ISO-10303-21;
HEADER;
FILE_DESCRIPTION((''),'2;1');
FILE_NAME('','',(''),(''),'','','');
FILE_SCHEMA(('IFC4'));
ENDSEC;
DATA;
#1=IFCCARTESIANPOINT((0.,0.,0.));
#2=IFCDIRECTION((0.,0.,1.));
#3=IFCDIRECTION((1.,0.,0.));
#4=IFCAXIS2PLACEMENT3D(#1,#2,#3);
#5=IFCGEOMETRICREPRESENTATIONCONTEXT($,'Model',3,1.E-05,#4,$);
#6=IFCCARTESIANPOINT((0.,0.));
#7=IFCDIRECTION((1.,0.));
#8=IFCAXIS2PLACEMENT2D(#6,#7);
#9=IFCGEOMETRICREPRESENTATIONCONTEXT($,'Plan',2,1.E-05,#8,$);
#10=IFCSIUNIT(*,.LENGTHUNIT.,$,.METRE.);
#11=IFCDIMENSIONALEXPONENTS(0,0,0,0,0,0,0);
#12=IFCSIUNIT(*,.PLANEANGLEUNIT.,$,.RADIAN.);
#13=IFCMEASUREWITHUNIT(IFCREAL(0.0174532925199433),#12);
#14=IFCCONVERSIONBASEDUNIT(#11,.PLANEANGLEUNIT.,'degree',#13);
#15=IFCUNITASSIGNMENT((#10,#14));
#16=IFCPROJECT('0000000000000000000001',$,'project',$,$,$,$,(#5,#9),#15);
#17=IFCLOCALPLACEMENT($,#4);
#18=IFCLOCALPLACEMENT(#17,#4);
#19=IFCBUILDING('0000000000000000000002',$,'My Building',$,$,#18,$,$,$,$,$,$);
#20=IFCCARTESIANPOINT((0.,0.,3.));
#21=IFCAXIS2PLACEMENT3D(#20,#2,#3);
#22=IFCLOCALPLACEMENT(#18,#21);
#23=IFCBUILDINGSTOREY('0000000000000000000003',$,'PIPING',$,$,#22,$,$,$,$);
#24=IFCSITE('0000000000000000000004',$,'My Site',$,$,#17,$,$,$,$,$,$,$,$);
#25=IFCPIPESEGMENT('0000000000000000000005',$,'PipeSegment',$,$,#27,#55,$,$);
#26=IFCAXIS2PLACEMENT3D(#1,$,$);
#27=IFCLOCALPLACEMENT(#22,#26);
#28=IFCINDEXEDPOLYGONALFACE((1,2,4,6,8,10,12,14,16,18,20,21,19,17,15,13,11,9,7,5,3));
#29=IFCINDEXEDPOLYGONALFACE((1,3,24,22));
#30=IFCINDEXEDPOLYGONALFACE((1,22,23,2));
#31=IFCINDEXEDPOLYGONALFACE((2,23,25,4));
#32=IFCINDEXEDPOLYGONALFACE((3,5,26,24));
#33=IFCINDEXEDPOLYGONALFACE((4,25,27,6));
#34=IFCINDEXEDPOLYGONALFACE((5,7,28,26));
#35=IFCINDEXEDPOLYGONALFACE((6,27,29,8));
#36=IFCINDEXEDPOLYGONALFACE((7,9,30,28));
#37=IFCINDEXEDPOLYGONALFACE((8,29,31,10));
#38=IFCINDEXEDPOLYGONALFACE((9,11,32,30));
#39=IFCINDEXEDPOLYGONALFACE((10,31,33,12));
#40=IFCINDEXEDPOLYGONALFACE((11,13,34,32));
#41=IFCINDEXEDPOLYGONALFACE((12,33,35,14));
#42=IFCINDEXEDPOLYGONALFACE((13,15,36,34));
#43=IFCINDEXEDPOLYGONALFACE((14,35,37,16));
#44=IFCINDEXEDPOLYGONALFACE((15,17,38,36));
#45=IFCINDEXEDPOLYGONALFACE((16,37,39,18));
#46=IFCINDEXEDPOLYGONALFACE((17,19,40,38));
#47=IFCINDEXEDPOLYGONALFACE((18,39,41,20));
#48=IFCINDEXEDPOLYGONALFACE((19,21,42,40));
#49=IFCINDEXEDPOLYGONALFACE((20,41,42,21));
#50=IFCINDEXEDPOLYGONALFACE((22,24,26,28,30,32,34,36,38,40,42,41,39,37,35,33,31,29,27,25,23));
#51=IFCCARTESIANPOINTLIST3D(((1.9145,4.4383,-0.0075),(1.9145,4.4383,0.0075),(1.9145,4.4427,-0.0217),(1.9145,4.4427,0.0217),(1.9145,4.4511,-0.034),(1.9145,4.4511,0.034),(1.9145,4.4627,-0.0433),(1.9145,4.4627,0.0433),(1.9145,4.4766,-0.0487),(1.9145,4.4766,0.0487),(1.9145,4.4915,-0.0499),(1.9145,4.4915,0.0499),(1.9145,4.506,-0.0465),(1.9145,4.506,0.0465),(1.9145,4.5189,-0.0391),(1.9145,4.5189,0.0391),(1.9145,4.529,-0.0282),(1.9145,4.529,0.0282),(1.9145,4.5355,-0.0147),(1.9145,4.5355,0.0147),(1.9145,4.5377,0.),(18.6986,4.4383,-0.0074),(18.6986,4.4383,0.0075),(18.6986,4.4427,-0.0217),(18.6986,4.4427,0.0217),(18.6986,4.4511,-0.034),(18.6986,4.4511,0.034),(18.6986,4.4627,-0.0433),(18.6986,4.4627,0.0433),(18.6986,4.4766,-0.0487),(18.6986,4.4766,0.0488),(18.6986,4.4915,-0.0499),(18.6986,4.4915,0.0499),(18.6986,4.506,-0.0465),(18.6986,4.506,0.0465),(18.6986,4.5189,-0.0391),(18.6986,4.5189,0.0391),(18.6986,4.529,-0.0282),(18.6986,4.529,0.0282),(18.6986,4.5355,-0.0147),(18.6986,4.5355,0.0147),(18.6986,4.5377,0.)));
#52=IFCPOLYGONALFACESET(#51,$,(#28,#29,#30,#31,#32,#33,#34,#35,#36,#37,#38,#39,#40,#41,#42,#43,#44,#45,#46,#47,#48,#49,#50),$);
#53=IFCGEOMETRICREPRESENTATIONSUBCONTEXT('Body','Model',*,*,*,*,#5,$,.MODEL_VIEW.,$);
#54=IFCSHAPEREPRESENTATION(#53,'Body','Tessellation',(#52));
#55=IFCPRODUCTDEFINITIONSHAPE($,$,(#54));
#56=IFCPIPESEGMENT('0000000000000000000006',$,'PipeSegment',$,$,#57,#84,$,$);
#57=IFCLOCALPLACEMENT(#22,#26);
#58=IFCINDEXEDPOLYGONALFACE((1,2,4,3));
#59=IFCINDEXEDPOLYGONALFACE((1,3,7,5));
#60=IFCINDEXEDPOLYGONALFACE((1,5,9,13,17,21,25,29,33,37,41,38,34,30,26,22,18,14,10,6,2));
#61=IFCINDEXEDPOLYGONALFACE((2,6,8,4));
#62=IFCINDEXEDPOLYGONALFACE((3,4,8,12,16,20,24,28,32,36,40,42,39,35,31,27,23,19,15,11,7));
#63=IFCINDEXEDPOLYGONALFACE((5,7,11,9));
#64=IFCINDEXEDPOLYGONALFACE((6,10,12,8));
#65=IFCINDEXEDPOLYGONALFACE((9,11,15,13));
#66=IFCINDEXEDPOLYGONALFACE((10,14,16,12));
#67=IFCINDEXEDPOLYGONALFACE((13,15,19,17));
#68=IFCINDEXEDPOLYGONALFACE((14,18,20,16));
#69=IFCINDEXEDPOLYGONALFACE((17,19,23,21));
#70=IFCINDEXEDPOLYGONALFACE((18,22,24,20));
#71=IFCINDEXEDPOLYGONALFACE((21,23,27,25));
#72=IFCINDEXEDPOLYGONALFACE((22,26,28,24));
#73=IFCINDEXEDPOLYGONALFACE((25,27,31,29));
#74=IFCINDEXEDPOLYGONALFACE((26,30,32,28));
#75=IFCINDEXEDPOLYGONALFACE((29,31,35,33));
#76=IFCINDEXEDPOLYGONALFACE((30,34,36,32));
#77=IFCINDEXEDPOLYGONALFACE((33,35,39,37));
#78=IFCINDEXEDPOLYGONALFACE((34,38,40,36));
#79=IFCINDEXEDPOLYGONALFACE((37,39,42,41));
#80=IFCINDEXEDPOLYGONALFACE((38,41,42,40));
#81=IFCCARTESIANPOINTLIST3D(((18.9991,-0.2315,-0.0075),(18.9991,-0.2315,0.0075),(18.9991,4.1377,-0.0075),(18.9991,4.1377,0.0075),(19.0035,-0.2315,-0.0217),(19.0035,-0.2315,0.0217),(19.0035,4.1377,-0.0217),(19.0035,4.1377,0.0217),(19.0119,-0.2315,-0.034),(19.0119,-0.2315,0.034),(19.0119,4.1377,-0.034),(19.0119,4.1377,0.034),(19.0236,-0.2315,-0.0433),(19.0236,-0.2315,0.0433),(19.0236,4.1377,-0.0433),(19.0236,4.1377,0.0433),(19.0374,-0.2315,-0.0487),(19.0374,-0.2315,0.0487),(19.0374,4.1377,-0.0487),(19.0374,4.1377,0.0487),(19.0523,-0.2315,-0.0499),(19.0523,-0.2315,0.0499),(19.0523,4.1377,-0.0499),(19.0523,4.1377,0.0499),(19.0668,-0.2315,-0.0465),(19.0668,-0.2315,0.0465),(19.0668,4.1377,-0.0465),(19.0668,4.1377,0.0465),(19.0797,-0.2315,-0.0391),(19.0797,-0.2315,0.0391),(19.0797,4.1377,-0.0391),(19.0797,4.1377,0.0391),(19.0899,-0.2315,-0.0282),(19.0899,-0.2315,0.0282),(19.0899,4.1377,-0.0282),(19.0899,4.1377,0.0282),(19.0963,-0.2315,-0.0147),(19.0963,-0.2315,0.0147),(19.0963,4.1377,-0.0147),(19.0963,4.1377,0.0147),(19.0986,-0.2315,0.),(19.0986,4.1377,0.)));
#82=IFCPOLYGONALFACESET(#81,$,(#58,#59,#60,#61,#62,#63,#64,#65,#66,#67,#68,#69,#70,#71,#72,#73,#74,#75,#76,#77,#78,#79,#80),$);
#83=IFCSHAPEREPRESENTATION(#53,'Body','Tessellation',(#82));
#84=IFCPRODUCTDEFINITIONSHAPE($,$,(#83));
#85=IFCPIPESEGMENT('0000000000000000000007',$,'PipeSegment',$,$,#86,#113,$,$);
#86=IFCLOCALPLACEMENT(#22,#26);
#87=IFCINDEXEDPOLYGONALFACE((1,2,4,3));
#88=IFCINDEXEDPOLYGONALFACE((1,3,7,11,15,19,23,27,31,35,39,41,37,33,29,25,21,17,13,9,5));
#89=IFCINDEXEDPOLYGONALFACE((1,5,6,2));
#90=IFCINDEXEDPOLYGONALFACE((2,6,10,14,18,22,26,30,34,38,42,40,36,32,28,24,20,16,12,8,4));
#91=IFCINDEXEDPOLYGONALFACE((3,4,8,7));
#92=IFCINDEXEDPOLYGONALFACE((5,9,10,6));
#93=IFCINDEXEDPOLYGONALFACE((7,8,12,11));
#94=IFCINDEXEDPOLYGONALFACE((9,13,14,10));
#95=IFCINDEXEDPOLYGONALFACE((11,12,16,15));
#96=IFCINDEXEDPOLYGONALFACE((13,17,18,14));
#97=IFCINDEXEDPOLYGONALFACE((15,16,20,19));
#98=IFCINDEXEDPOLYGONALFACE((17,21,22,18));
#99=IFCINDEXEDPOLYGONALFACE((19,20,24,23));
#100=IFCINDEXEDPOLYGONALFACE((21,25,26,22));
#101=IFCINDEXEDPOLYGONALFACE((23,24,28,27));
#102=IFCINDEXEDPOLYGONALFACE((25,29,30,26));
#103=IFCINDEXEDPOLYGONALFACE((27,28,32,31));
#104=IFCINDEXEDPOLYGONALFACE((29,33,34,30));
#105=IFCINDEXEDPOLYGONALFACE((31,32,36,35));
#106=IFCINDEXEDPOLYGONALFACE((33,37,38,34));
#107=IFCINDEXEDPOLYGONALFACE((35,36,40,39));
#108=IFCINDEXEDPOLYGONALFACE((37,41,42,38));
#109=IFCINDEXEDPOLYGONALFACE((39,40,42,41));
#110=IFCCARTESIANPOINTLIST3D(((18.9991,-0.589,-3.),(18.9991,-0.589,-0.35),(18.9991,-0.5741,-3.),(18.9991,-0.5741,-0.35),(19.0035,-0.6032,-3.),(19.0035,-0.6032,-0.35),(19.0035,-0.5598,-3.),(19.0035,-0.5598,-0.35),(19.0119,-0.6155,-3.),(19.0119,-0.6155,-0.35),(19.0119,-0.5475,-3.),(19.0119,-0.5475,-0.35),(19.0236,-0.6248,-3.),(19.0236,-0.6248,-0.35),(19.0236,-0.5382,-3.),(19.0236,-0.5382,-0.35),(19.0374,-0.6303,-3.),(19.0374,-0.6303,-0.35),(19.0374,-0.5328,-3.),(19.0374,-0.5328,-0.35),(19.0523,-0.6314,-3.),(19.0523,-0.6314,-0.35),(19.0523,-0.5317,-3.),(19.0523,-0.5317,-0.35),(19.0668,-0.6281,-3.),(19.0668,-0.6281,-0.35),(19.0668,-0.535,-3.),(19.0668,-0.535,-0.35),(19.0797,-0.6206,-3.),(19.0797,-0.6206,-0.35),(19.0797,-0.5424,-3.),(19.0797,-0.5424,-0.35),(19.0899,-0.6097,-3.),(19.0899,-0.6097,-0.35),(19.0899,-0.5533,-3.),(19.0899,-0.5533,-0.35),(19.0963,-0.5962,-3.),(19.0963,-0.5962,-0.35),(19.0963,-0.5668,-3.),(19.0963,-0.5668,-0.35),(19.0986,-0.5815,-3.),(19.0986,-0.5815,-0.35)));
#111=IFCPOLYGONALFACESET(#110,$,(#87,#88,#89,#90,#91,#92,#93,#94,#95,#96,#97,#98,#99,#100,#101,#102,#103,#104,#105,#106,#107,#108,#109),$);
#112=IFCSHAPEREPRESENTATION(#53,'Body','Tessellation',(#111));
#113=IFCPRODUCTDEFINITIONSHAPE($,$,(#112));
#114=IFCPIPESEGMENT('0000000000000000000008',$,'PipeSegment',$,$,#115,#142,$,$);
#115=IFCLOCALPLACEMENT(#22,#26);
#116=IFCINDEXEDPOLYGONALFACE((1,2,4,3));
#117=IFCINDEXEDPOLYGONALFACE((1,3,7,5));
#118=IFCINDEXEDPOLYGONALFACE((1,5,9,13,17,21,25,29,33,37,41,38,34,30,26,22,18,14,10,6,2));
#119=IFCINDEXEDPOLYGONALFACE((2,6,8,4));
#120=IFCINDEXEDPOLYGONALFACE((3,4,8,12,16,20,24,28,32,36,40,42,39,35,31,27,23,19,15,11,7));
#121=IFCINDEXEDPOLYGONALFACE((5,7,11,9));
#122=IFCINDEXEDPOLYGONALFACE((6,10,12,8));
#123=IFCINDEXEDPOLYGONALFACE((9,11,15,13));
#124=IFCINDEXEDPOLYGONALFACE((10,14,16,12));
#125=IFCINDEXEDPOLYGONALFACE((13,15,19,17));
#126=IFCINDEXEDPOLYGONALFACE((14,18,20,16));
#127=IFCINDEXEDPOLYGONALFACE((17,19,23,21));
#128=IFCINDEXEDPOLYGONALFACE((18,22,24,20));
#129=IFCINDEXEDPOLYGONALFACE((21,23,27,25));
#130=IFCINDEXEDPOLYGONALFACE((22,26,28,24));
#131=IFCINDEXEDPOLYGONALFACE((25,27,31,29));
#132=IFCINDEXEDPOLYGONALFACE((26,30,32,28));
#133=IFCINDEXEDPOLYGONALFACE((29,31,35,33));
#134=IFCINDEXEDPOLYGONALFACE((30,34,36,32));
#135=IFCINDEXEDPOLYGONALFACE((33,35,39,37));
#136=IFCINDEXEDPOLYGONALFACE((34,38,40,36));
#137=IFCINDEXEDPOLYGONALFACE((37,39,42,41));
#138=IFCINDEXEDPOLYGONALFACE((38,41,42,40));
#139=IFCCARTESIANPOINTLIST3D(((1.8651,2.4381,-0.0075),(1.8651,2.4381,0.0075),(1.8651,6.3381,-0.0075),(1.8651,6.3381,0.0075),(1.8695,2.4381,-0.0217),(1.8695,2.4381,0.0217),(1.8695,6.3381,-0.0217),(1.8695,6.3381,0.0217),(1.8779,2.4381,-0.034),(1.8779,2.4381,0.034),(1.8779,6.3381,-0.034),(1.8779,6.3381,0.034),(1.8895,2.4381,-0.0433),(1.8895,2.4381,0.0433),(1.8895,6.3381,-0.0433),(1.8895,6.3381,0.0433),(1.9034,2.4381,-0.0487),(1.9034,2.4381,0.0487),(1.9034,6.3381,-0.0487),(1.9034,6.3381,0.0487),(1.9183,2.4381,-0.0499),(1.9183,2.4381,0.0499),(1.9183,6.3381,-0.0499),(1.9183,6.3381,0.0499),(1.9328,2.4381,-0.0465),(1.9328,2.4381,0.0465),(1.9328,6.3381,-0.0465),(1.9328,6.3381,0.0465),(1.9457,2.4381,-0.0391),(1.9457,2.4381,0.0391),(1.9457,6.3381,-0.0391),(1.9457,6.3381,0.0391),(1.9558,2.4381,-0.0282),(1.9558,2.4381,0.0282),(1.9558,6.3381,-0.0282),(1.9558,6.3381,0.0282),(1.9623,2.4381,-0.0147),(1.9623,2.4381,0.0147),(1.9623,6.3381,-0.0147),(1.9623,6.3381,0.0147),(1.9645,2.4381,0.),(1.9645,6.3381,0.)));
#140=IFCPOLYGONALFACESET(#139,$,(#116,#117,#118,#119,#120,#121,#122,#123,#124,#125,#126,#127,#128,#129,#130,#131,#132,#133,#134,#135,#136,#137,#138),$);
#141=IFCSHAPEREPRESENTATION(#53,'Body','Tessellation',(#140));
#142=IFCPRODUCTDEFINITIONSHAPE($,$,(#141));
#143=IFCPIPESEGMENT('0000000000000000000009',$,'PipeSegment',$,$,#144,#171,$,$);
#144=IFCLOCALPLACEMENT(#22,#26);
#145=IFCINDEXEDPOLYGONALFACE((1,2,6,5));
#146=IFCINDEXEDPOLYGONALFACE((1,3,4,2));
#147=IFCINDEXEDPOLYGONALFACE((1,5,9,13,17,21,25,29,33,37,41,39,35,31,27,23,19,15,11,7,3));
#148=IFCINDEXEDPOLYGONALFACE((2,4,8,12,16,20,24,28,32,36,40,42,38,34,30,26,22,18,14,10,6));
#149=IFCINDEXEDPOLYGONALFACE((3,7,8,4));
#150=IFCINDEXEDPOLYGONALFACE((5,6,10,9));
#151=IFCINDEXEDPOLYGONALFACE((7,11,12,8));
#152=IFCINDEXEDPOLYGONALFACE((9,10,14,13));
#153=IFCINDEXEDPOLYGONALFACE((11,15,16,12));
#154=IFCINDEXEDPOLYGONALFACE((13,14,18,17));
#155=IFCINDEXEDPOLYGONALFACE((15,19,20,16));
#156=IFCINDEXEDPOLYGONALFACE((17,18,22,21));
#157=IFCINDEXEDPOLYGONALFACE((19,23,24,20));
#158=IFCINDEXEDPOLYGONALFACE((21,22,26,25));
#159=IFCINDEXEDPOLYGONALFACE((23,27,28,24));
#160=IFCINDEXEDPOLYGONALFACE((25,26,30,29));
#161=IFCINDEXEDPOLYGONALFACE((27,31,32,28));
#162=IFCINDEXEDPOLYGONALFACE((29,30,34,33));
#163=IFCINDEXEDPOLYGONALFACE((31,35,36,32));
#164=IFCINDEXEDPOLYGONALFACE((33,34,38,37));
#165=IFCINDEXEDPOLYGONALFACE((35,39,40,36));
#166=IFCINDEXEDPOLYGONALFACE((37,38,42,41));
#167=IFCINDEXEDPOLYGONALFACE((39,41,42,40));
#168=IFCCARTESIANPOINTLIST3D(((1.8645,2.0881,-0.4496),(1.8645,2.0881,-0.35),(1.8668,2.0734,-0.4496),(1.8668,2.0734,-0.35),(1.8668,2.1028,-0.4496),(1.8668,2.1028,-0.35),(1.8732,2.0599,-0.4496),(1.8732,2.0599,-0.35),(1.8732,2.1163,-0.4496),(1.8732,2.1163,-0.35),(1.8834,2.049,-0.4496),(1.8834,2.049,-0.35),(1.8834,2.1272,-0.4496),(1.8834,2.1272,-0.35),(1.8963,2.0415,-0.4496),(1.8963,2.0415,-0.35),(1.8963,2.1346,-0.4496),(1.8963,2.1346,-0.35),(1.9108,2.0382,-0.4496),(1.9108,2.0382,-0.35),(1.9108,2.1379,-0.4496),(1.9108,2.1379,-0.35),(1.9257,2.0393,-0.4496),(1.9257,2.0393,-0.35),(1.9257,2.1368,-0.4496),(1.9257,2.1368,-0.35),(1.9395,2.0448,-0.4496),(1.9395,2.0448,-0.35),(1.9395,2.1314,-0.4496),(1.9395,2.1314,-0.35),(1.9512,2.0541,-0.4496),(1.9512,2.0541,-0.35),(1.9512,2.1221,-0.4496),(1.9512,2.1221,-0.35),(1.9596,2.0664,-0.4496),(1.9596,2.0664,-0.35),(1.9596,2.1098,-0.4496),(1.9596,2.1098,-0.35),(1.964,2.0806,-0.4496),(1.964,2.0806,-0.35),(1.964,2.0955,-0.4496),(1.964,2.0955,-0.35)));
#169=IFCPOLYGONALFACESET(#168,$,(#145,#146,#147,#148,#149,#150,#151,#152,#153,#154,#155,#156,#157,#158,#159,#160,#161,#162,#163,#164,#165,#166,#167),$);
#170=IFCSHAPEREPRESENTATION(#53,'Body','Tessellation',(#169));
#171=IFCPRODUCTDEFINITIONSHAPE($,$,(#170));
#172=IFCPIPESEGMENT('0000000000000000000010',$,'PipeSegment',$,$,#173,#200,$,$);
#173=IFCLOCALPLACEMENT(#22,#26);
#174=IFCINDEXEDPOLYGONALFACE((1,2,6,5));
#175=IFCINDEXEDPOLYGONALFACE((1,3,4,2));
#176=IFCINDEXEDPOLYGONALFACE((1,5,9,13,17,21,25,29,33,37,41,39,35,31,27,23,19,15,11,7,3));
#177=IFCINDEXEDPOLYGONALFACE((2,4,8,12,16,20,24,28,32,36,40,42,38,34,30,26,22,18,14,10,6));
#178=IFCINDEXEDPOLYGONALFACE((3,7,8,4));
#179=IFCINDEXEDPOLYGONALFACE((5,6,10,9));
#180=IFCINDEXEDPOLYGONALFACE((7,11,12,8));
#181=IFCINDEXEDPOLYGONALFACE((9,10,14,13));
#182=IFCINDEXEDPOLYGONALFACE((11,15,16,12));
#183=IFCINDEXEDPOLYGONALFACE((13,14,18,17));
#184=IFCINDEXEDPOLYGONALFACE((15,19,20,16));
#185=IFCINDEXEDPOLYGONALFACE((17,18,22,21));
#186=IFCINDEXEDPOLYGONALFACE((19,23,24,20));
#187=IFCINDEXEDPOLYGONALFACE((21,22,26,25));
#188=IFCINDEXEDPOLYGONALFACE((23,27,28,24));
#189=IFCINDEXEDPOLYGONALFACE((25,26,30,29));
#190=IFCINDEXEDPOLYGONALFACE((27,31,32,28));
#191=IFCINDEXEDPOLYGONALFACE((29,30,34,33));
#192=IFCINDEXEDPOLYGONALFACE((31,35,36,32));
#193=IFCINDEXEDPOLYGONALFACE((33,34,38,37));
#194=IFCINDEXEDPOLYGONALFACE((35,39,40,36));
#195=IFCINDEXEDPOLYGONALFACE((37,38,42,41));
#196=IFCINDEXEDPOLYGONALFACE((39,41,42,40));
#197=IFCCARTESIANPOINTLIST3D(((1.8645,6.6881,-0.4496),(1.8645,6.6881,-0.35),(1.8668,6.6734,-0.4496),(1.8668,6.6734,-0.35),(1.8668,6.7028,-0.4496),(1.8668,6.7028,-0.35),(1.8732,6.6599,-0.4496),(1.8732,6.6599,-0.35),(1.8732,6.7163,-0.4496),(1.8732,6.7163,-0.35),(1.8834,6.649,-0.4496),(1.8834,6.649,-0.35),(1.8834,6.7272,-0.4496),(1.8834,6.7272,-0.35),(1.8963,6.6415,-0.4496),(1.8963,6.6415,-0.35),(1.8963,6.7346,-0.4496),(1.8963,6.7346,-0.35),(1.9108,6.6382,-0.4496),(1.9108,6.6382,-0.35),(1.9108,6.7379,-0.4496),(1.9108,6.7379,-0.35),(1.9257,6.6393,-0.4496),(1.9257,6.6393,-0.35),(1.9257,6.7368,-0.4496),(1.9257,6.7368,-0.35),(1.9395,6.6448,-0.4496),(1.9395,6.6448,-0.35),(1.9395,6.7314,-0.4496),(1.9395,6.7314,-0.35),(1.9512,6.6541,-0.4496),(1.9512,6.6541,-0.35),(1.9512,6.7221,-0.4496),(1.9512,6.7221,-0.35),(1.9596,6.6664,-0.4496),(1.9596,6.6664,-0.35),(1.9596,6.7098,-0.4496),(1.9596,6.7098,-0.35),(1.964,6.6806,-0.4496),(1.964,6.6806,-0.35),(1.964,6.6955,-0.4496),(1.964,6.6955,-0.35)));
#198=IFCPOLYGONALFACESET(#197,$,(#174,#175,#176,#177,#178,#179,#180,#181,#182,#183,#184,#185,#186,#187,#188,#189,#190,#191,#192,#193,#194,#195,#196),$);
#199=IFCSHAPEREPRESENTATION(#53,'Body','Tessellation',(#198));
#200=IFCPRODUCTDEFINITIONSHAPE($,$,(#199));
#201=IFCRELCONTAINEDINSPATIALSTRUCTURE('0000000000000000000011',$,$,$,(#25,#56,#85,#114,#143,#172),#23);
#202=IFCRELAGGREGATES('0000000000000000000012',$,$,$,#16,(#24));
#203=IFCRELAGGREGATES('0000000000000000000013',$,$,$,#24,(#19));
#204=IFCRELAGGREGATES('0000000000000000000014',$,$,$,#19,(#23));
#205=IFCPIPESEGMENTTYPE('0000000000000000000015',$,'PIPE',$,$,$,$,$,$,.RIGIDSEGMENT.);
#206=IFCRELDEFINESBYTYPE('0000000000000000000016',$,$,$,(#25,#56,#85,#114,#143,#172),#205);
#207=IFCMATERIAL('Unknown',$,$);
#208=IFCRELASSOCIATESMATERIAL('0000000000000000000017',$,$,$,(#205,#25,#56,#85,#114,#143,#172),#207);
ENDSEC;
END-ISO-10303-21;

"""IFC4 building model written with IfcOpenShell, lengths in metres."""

from ifc_helpers import new_model, entity, si_unit, converted_unit, frame, origin_with_axes, origin_2d_with_axis, place, context, subcontext, project, spatial, circle, extrude, material, material_profile, profile_set, profile_usage, type_object, element, save


model = new_model("IFC4")

# Units and contexts
model_context = context("Model", 3, precision=1e-05, world=origin_with_axes())
plan_context = context("Plan", 2, precision=1e-05, world=origin_2d_with_axis())
body_context = subcontext(model_context, "Body", "Model", "MODEL_VIEW")
ifc_project = project(units=[si_unit("LENGTHUNIT", "METRE"), converted_unit("PLANEANGLEUNIT", "degree", entity("IfcReal", 0.0174532925199433), si_unit("PLANEANGLEUNIT", "RADIAN"), dimensions=[0, 0, 0, 0, 0, 0, 0])], contexts=[model_context, plan_context])

# Site, building, storey
site_placement = place(None, origin_with_axes())
site = spatial("IfcSite", under=ifc_project, at=site_placement, Name="My Site")
building_placement = place(site_placement, origin_with_axes())
building = spatial("IfcBuilding", under=site, at=building_placement, Name="My Building")
storey_placement = place(building_placement, frame((0.0, 0.0, 3.0), z_axis=(0.0, 0.0, 1.0), x_axis=(1.0, 0.0, 0.0)))
storey = spatial("IfcBuildingStorey", under=building, at=storey_placement, Name="PIPING")

# Pipe segments
ifc_material = material(Name="Unknown")
ifc_material_profile = material_profile(ifc_material, circle(Radius=0.05))
ifc_profile_set = profile_set([ifc_material_profile])
ifc_profile_usage_1 = profile_usage(ifc_profile_set, cardinal=5)
pipe_segment_type = type_object("IfcPipeSegmentType", Name="PIPE", PredefinedType="RIGIDSEGMENT", material=ifc_profile_set)
pipe_segment_1_placement = place(storey_placement, frame((1.9145, 4.4877, 0.0), z_axis=(1.0, 0.0, 0.0), x_axis=(0.0, 1.0, 0.0)))
element("IfcPipeSegment", 1, at=pipe_segment_1_placement, inside=storey, type_object=pipe_segment_type, material=ifc_profile_usage_1, Name="PipeSegment", context=body_context, shape_type="SweptSolid", body=[
    extrude(circle(Radius=0.05), origin_with_axes(), (0.0, 0.0, 1.0), 16.784),
])
ifc_profile_usage_2 = profile_usage(ifc_profile_set, cardinal=5)
pipe_segment_2_placement = place(storey_placement, frame((19.0486, 4.1377, 0.0), z_axis=(0.0, -1.0, 0.0), x_axis=(1.0, 0.0, 0.0)))
element("IfcPipeSegment", 2, at=pipe_segment_2_placement, inside=storey, type_object=pipe_segment_type, material=ifc_profile_usage_2, Name="PipeSegment", context=body_context, shape_type="SweptSolid", body=[
    extrude(circle(Radius=0.05), origin_with_axes(), (0.0, 0.0, 1.0), 4.3692),
])
ifc_profile_usage_3 = profile_usage(ifc_profile_set, cardinal=5)
pipe_segment_3_placement = place(storey_placement, frame((19.0486, -0.5815, -0.35), z_axis=(0.0, 0.0, -1.0), x_axis=(1.0, 0.0, 0.0)))
element("IfcPipeSegment", 3, at=pipe_segment_3_placement, inside=storey, type_object=pipe_segment_type, material=ifc_profile_usage_3, Name="PipeSegment", context=body_context, shape_type="SweptSolid", body=[
    extrude(circle(Radius=0.05), origin_with_axes(), (0.0, 0.0, 1.0), 2.65),
])
ifc_profile_usage_4 = profile_usage(ifc_profile_set, cardinal=5)
pipe_segment_4_placement = place(storey_placement, frame((1.9145, 6.3381, 0.0), z_axis=(0.0, -1.0, 0.0), x_axis=(1.0, 0.0, 0.0)))
element("IfcPipeSegment", 4, at=pipe_segment_4_placement, inside=storey, type_object=pipe_segment_type, material=ifc_profile_usage_4, Name="PipeSegment", context=body_context, shape_type="SweptSolid", body=[
    extrude(circle(Radius=0.05), origin_with_axes(), (0.0, 0.0, 1.0), 3.9),
])
ifc_profile_usage_5 = profile_usage(ifc_profile_set, cardinal=5)
pipe_segment_5_placement = place(storey_placement, frame((1.9145, 2.0881, -0.35), z_axis=(0.0, 0.0, -1.0), x_axis=(-1.0, 0.0, 0.0)))
element("IfcPipeSegment", 5, at=pipe_segment_5_placement, inside=storey, type_object=pipe_segment_type, material=ifc_profile_usage_5, Name="PipeSegment", context=body_context, shape_type="SweptSolid", body=[
    extrude(circle(Radius=0.05), origin_with_axes(), (0.0, 0.0, 1.0), 0.0996),
])
ifc_profile_usage_6 = profile_usage(ifc_profile_set, cardinal=5)
pipe_segment_6_placement = place(storey_placement, frame((1.9145, 6.6881, -0.35), z_axis=(0.0, 0.0, -1.0), x_axis=(-1.0, 0.0, 0.0)))
element("IfcPipeSegment", 6, at=pipe_segment_6_placement, inside=storey, type_object=pipe_segment_type, material=ifc_profile_usage_6, Name="PipeSegment", context=body_context, shape_type="SweptSolid", body=[
    extrude(circle(Radius=0.05), origin_with_axes(), (0.0, 0.0, 1.0), 0.0996),
])

save(model, "model.ifc")
